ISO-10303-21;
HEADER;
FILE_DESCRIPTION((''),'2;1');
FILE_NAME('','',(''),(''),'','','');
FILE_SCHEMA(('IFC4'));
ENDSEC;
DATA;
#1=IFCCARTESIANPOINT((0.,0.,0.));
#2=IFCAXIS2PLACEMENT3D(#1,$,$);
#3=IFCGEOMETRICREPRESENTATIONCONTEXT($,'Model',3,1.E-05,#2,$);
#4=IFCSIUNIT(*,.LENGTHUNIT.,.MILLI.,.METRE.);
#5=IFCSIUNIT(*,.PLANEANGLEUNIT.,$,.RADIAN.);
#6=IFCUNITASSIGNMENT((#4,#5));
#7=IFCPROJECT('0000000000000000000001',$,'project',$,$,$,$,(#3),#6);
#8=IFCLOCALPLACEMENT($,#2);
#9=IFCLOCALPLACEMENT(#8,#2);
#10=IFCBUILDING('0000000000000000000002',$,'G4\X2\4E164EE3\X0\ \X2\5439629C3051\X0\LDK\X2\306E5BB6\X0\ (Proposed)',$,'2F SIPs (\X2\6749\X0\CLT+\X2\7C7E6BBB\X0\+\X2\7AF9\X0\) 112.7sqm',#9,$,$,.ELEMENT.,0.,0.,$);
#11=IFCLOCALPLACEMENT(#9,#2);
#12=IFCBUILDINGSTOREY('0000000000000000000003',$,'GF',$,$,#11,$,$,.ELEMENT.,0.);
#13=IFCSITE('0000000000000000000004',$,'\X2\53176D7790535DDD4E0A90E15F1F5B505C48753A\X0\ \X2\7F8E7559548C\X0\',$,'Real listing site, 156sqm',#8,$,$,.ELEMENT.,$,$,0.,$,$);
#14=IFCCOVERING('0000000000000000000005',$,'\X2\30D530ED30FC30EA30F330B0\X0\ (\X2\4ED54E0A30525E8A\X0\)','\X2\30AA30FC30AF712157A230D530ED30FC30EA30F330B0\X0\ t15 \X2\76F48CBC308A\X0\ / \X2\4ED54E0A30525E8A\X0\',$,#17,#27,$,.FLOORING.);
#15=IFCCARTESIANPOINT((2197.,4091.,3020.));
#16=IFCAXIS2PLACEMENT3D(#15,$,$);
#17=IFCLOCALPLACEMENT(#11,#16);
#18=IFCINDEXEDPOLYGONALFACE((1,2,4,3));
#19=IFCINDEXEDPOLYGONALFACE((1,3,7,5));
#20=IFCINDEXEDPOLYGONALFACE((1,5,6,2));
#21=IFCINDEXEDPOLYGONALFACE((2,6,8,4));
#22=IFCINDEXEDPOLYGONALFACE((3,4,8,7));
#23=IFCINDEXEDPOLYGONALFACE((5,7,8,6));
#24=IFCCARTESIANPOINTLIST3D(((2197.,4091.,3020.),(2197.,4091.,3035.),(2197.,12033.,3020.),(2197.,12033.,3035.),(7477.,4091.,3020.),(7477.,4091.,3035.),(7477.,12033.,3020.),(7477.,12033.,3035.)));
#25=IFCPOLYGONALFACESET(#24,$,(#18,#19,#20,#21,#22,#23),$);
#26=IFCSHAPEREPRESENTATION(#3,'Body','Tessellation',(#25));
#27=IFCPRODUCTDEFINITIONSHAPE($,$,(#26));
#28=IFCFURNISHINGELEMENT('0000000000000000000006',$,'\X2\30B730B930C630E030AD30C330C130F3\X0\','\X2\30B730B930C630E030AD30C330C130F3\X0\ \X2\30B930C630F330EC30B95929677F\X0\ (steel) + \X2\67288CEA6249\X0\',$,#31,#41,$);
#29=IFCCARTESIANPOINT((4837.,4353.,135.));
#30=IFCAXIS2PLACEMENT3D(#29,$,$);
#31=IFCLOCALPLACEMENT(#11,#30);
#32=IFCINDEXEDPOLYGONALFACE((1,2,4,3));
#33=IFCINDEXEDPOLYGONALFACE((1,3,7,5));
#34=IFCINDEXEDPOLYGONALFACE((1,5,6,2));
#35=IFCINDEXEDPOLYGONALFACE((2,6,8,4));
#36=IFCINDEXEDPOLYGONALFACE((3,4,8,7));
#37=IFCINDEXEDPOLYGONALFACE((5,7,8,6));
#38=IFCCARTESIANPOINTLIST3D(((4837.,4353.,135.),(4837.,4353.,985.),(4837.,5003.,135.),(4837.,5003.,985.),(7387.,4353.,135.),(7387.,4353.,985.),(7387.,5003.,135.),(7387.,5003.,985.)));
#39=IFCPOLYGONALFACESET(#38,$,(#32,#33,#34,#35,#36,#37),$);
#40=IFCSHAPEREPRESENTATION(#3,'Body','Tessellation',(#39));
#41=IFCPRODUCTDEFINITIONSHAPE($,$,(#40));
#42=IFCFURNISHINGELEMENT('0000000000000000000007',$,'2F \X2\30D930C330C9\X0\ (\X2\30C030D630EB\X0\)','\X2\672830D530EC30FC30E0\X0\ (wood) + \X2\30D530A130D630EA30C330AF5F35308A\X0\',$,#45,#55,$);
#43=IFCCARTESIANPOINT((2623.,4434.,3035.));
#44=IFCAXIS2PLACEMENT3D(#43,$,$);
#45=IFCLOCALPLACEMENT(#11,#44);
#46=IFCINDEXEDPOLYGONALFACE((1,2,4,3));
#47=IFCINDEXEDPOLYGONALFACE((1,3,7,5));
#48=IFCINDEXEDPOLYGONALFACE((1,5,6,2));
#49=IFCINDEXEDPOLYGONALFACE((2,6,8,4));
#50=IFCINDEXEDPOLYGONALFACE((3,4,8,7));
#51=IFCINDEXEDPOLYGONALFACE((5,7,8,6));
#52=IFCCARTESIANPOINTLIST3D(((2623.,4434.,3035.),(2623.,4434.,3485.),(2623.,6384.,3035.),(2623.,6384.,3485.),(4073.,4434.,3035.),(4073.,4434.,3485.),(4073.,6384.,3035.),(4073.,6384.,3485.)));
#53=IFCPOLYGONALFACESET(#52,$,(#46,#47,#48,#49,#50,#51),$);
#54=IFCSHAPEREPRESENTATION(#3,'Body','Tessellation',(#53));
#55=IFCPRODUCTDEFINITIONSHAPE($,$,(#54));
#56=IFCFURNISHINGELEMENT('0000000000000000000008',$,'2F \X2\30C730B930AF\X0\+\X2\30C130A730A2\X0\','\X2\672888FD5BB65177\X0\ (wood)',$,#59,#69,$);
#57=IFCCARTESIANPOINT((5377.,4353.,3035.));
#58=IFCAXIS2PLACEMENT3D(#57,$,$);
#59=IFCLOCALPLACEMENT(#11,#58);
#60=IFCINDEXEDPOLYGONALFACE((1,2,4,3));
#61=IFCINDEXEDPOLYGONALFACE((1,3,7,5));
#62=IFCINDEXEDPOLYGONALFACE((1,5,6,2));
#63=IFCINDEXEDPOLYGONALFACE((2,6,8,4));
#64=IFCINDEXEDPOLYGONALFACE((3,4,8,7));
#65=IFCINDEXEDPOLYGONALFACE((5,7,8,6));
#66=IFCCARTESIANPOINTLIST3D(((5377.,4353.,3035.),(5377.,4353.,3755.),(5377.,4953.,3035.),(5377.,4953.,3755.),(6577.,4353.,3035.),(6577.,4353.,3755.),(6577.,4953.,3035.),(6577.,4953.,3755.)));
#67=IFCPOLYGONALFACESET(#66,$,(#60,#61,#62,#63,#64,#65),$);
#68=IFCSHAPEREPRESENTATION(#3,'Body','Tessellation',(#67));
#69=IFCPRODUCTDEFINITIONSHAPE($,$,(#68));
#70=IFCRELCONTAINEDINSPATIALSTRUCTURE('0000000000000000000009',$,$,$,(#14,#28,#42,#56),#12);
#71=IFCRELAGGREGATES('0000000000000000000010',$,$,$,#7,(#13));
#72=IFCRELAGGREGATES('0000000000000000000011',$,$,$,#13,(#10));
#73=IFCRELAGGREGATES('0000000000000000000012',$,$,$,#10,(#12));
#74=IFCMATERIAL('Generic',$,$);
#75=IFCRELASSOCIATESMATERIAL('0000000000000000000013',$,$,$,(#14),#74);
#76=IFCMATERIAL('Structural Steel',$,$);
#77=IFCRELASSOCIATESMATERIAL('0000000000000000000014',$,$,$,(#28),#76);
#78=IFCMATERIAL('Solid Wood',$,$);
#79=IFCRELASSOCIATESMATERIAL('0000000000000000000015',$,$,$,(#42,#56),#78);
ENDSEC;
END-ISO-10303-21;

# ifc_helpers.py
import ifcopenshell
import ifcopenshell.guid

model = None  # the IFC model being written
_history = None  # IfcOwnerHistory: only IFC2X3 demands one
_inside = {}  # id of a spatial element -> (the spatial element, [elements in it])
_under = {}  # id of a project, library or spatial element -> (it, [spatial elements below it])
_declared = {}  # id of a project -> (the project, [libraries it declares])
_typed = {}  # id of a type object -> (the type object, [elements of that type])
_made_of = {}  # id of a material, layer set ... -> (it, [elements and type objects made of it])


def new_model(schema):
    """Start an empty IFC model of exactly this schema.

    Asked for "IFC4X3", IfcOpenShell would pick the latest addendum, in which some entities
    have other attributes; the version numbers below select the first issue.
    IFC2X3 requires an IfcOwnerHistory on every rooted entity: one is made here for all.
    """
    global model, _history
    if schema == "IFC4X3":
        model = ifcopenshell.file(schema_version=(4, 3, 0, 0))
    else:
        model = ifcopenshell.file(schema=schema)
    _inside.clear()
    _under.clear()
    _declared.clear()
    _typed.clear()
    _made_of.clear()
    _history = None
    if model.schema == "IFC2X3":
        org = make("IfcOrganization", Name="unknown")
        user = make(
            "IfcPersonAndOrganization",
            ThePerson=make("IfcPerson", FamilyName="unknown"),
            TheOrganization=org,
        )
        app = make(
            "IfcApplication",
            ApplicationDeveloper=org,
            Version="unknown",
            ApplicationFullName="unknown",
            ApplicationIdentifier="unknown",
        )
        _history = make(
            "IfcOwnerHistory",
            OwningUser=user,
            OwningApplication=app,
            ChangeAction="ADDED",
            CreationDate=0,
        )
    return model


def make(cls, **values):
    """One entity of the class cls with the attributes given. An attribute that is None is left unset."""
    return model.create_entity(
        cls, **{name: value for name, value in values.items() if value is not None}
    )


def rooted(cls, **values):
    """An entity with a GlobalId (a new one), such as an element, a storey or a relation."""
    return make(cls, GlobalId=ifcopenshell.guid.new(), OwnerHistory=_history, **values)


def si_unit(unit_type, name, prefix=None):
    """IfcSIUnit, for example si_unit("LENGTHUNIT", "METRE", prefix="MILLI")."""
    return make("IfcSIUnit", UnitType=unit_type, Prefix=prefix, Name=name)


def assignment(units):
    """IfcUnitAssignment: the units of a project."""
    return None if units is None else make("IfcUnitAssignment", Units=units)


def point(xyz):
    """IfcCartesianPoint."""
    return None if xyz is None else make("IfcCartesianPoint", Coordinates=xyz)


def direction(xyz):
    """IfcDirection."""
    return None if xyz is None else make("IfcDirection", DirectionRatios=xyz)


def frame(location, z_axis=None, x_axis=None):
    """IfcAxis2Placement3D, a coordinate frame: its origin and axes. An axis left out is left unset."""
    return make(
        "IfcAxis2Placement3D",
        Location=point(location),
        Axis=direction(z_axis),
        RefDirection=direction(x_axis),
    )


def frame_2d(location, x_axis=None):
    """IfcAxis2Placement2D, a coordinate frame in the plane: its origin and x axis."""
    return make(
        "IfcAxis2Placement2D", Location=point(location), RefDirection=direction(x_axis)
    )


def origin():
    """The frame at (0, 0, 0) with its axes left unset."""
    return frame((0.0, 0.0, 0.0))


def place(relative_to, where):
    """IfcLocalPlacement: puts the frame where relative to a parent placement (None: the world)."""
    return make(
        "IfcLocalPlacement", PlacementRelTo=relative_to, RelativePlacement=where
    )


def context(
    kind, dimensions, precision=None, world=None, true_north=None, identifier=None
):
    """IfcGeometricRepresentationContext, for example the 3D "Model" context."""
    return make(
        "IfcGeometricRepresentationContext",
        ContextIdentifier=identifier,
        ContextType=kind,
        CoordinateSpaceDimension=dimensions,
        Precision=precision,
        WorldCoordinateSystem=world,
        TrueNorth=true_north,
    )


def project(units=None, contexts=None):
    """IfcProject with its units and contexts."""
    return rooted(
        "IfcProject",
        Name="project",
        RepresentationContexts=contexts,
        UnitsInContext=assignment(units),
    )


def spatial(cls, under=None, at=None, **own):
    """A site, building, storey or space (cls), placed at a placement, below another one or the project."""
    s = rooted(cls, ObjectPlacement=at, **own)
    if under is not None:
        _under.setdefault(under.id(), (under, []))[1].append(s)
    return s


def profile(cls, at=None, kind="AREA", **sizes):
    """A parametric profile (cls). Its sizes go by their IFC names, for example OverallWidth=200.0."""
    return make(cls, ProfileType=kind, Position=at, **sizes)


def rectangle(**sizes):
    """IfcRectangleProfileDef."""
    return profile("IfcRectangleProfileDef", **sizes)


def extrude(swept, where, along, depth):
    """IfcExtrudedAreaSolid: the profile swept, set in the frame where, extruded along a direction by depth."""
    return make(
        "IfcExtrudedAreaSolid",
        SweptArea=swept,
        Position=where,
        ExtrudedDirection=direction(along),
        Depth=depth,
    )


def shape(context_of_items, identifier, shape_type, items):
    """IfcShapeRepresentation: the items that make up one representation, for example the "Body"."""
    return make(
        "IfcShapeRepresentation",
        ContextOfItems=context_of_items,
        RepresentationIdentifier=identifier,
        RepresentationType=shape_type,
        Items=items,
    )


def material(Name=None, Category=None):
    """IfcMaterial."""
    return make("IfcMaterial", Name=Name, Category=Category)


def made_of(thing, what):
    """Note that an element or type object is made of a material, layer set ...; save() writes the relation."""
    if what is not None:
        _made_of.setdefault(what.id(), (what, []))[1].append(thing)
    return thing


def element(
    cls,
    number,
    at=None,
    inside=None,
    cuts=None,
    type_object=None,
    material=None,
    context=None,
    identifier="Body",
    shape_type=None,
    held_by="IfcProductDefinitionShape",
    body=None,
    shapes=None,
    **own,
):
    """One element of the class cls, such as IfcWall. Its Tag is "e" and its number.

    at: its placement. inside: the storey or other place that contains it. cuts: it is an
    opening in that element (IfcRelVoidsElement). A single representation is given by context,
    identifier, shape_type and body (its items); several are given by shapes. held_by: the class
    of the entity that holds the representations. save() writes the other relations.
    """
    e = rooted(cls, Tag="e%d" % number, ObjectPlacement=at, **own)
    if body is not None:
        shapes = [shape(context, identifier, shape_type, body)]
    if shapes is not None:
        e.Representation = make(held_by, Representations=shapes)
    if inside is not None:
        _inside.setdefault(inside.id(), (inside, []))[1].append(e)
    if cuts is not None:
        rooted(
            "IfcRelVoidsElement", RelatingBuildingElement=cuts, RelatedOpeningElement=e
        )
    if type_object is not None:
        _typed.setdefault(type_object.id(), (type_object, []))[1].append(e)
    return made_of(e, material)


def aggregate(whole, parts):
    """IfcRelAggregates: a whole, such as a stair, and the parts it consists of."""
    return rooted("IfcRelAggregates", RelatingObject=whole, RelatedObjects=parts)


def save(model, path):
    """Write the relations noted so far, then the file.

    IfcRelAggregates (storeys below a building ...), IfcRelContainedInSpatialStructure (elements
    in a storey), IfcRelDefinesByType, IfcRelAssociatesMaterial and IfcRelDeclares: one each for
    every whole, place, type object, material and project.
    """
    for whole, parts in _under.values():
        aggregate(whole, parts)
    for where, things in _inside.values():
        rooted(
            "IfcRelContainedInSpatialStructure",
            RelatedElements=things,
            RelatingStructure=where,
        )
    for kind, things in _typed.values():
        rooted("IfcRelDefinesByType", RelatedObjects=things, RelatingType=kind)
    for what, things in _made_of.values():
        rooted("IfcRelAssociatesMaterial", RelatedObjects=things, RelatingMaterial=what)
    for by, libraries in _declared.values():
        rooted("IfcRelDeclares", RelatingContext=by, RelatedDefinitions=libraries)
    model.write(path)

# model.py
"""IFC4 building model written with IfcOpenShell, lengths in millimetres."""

from ifc_helpers import new_model, si_unit, frame, frame_2d, origin, place, context, project, spatial, rectangle, extrude, material, element, save


model = new_model("IFC4")

# Units and contexts
model_context = context("Model", 3, precision=1e-05, world=origin())
ifc_project = project(units=[si_unit("LENGTHUNIT", "METRE", prefix="MILLI"), si_unit("PLANEANGLEUNIT", "RADIAN")], contexts=[model_context])

# Site, building, storey
site_placement = place(None, origin())
site = spatial("IfcSite", under=ifc_project, at=site_placement, Name="北海道川上郡弟子屈町 美留和", ObjectType="Real listing site, 156sqm", CompositionType="ELEMENT", RefElevation=0.0)
building_placement = place(site_placement, origin())
building = spatial("IfcBuilding", under=site, at=building_placement, Name="G4世代 吹抜けLDKの家 (Proposed)", ObjectType="2F SIPs (杉CLT+籾殻+竹) 112.7sqm", CompositionType="ELEMENT", ElevationOfRefHeight=0.0, ElevationOfTerrain=0.0)
storey_placement = place(building_placement, origin())
storey = spatial("IfcBuildingStorey", under=building, at=storey_placement, Name="GF", CompositionType="ELEMENT", Elevation=0.0)

# Shared definitions
ifc_material_1 = material(Name="Solid Wood")

# Shared definitions
ifc_material_2 = material(Name="Generic")

# Shared definitions
ifc_material_3 = material(Name="Structural Steel")

# Covering
covering_placement = place(storey_placement, frame((2197.0, 4091.0, 3020.0)))
element("IfcCovering", 1, at=covering_placement, inside=storey, material=ifc_material_2, Name="フローリング (仕上げ床)", Description="オーク無垢フローリング t15 直貼り / 仕上げ床", PredefinedType="FLOORING", context=model_context, shape_type="SweptSolid", body=[
    extrude(rectangle(XDim=5280.0, YDim=7942.0, at=frame_2d((2640.0, 3971.0))), frame((2197.0, 4091.0, 3020.0)), (0.0, 0.0, 1.0), 15.0),
])

# Furnishing elements
furnishing_1_placement = place(storey_placement, frame((4837.0, 4353.0, 135.0)))
element("IfcFurnishingElement", 2, at=furnishing_1_placement, inside=storey, material=ifc_material_3, Name="システムキッチン", Description="システムキッチン ステンレス天板 (steel) + 木質扉", context=model_context, shape_type="SweptSolid", body=[
    extrude(rectangle(XDim=2550.0, YDim=650.0, at=frame_2d((1275.0, 325.0))), frame((4837.0, 4353.0, 135.0)), (0.0, 0.0, 1.0), 850.0),
])
furnishing_2_placement = place(storey_placement, frame((2623.0, 4434.0, 3035.0)))
element("IfcFurnishingElement", 3, at=furnishing_2_placement, inside=storey, material=ifc_material_1, Name="2F ベッド (ダブル)", Description="木フレーム (wood) + ファブリック張り", context=model_context, shape_type="SweptSolid", body=[
    extrude(rectangle(XDim=1450.0, YDim=1950.0, at=frame_2d((725.0, 975.0))), frame((2623.0, 4434.0, 3035.0)), (0.0, 0.0, 1.0), 450.0),
])
furnishing_3_placement = place(storey_placement, frame((5377.0, 4353.0, 3035.0)))
element("IfcFurnishingElement", 4, at=furnishing_3_placement, inside=storey, material=ifc_material_1, Name="2F デスク+チェア", Description="木製家具 (wood)", context=model_context, shape_type="SweptSolid", body=[
    extrude(rectangle(XDim=1200.0, YDim=600.0, at=frame_2d((600.0, 300.0))), frame((5377.0, 4353.0, 3035.0)), (0.0, 0.0, 1.0), 720.0),
])

save(model, "model.ifc")
